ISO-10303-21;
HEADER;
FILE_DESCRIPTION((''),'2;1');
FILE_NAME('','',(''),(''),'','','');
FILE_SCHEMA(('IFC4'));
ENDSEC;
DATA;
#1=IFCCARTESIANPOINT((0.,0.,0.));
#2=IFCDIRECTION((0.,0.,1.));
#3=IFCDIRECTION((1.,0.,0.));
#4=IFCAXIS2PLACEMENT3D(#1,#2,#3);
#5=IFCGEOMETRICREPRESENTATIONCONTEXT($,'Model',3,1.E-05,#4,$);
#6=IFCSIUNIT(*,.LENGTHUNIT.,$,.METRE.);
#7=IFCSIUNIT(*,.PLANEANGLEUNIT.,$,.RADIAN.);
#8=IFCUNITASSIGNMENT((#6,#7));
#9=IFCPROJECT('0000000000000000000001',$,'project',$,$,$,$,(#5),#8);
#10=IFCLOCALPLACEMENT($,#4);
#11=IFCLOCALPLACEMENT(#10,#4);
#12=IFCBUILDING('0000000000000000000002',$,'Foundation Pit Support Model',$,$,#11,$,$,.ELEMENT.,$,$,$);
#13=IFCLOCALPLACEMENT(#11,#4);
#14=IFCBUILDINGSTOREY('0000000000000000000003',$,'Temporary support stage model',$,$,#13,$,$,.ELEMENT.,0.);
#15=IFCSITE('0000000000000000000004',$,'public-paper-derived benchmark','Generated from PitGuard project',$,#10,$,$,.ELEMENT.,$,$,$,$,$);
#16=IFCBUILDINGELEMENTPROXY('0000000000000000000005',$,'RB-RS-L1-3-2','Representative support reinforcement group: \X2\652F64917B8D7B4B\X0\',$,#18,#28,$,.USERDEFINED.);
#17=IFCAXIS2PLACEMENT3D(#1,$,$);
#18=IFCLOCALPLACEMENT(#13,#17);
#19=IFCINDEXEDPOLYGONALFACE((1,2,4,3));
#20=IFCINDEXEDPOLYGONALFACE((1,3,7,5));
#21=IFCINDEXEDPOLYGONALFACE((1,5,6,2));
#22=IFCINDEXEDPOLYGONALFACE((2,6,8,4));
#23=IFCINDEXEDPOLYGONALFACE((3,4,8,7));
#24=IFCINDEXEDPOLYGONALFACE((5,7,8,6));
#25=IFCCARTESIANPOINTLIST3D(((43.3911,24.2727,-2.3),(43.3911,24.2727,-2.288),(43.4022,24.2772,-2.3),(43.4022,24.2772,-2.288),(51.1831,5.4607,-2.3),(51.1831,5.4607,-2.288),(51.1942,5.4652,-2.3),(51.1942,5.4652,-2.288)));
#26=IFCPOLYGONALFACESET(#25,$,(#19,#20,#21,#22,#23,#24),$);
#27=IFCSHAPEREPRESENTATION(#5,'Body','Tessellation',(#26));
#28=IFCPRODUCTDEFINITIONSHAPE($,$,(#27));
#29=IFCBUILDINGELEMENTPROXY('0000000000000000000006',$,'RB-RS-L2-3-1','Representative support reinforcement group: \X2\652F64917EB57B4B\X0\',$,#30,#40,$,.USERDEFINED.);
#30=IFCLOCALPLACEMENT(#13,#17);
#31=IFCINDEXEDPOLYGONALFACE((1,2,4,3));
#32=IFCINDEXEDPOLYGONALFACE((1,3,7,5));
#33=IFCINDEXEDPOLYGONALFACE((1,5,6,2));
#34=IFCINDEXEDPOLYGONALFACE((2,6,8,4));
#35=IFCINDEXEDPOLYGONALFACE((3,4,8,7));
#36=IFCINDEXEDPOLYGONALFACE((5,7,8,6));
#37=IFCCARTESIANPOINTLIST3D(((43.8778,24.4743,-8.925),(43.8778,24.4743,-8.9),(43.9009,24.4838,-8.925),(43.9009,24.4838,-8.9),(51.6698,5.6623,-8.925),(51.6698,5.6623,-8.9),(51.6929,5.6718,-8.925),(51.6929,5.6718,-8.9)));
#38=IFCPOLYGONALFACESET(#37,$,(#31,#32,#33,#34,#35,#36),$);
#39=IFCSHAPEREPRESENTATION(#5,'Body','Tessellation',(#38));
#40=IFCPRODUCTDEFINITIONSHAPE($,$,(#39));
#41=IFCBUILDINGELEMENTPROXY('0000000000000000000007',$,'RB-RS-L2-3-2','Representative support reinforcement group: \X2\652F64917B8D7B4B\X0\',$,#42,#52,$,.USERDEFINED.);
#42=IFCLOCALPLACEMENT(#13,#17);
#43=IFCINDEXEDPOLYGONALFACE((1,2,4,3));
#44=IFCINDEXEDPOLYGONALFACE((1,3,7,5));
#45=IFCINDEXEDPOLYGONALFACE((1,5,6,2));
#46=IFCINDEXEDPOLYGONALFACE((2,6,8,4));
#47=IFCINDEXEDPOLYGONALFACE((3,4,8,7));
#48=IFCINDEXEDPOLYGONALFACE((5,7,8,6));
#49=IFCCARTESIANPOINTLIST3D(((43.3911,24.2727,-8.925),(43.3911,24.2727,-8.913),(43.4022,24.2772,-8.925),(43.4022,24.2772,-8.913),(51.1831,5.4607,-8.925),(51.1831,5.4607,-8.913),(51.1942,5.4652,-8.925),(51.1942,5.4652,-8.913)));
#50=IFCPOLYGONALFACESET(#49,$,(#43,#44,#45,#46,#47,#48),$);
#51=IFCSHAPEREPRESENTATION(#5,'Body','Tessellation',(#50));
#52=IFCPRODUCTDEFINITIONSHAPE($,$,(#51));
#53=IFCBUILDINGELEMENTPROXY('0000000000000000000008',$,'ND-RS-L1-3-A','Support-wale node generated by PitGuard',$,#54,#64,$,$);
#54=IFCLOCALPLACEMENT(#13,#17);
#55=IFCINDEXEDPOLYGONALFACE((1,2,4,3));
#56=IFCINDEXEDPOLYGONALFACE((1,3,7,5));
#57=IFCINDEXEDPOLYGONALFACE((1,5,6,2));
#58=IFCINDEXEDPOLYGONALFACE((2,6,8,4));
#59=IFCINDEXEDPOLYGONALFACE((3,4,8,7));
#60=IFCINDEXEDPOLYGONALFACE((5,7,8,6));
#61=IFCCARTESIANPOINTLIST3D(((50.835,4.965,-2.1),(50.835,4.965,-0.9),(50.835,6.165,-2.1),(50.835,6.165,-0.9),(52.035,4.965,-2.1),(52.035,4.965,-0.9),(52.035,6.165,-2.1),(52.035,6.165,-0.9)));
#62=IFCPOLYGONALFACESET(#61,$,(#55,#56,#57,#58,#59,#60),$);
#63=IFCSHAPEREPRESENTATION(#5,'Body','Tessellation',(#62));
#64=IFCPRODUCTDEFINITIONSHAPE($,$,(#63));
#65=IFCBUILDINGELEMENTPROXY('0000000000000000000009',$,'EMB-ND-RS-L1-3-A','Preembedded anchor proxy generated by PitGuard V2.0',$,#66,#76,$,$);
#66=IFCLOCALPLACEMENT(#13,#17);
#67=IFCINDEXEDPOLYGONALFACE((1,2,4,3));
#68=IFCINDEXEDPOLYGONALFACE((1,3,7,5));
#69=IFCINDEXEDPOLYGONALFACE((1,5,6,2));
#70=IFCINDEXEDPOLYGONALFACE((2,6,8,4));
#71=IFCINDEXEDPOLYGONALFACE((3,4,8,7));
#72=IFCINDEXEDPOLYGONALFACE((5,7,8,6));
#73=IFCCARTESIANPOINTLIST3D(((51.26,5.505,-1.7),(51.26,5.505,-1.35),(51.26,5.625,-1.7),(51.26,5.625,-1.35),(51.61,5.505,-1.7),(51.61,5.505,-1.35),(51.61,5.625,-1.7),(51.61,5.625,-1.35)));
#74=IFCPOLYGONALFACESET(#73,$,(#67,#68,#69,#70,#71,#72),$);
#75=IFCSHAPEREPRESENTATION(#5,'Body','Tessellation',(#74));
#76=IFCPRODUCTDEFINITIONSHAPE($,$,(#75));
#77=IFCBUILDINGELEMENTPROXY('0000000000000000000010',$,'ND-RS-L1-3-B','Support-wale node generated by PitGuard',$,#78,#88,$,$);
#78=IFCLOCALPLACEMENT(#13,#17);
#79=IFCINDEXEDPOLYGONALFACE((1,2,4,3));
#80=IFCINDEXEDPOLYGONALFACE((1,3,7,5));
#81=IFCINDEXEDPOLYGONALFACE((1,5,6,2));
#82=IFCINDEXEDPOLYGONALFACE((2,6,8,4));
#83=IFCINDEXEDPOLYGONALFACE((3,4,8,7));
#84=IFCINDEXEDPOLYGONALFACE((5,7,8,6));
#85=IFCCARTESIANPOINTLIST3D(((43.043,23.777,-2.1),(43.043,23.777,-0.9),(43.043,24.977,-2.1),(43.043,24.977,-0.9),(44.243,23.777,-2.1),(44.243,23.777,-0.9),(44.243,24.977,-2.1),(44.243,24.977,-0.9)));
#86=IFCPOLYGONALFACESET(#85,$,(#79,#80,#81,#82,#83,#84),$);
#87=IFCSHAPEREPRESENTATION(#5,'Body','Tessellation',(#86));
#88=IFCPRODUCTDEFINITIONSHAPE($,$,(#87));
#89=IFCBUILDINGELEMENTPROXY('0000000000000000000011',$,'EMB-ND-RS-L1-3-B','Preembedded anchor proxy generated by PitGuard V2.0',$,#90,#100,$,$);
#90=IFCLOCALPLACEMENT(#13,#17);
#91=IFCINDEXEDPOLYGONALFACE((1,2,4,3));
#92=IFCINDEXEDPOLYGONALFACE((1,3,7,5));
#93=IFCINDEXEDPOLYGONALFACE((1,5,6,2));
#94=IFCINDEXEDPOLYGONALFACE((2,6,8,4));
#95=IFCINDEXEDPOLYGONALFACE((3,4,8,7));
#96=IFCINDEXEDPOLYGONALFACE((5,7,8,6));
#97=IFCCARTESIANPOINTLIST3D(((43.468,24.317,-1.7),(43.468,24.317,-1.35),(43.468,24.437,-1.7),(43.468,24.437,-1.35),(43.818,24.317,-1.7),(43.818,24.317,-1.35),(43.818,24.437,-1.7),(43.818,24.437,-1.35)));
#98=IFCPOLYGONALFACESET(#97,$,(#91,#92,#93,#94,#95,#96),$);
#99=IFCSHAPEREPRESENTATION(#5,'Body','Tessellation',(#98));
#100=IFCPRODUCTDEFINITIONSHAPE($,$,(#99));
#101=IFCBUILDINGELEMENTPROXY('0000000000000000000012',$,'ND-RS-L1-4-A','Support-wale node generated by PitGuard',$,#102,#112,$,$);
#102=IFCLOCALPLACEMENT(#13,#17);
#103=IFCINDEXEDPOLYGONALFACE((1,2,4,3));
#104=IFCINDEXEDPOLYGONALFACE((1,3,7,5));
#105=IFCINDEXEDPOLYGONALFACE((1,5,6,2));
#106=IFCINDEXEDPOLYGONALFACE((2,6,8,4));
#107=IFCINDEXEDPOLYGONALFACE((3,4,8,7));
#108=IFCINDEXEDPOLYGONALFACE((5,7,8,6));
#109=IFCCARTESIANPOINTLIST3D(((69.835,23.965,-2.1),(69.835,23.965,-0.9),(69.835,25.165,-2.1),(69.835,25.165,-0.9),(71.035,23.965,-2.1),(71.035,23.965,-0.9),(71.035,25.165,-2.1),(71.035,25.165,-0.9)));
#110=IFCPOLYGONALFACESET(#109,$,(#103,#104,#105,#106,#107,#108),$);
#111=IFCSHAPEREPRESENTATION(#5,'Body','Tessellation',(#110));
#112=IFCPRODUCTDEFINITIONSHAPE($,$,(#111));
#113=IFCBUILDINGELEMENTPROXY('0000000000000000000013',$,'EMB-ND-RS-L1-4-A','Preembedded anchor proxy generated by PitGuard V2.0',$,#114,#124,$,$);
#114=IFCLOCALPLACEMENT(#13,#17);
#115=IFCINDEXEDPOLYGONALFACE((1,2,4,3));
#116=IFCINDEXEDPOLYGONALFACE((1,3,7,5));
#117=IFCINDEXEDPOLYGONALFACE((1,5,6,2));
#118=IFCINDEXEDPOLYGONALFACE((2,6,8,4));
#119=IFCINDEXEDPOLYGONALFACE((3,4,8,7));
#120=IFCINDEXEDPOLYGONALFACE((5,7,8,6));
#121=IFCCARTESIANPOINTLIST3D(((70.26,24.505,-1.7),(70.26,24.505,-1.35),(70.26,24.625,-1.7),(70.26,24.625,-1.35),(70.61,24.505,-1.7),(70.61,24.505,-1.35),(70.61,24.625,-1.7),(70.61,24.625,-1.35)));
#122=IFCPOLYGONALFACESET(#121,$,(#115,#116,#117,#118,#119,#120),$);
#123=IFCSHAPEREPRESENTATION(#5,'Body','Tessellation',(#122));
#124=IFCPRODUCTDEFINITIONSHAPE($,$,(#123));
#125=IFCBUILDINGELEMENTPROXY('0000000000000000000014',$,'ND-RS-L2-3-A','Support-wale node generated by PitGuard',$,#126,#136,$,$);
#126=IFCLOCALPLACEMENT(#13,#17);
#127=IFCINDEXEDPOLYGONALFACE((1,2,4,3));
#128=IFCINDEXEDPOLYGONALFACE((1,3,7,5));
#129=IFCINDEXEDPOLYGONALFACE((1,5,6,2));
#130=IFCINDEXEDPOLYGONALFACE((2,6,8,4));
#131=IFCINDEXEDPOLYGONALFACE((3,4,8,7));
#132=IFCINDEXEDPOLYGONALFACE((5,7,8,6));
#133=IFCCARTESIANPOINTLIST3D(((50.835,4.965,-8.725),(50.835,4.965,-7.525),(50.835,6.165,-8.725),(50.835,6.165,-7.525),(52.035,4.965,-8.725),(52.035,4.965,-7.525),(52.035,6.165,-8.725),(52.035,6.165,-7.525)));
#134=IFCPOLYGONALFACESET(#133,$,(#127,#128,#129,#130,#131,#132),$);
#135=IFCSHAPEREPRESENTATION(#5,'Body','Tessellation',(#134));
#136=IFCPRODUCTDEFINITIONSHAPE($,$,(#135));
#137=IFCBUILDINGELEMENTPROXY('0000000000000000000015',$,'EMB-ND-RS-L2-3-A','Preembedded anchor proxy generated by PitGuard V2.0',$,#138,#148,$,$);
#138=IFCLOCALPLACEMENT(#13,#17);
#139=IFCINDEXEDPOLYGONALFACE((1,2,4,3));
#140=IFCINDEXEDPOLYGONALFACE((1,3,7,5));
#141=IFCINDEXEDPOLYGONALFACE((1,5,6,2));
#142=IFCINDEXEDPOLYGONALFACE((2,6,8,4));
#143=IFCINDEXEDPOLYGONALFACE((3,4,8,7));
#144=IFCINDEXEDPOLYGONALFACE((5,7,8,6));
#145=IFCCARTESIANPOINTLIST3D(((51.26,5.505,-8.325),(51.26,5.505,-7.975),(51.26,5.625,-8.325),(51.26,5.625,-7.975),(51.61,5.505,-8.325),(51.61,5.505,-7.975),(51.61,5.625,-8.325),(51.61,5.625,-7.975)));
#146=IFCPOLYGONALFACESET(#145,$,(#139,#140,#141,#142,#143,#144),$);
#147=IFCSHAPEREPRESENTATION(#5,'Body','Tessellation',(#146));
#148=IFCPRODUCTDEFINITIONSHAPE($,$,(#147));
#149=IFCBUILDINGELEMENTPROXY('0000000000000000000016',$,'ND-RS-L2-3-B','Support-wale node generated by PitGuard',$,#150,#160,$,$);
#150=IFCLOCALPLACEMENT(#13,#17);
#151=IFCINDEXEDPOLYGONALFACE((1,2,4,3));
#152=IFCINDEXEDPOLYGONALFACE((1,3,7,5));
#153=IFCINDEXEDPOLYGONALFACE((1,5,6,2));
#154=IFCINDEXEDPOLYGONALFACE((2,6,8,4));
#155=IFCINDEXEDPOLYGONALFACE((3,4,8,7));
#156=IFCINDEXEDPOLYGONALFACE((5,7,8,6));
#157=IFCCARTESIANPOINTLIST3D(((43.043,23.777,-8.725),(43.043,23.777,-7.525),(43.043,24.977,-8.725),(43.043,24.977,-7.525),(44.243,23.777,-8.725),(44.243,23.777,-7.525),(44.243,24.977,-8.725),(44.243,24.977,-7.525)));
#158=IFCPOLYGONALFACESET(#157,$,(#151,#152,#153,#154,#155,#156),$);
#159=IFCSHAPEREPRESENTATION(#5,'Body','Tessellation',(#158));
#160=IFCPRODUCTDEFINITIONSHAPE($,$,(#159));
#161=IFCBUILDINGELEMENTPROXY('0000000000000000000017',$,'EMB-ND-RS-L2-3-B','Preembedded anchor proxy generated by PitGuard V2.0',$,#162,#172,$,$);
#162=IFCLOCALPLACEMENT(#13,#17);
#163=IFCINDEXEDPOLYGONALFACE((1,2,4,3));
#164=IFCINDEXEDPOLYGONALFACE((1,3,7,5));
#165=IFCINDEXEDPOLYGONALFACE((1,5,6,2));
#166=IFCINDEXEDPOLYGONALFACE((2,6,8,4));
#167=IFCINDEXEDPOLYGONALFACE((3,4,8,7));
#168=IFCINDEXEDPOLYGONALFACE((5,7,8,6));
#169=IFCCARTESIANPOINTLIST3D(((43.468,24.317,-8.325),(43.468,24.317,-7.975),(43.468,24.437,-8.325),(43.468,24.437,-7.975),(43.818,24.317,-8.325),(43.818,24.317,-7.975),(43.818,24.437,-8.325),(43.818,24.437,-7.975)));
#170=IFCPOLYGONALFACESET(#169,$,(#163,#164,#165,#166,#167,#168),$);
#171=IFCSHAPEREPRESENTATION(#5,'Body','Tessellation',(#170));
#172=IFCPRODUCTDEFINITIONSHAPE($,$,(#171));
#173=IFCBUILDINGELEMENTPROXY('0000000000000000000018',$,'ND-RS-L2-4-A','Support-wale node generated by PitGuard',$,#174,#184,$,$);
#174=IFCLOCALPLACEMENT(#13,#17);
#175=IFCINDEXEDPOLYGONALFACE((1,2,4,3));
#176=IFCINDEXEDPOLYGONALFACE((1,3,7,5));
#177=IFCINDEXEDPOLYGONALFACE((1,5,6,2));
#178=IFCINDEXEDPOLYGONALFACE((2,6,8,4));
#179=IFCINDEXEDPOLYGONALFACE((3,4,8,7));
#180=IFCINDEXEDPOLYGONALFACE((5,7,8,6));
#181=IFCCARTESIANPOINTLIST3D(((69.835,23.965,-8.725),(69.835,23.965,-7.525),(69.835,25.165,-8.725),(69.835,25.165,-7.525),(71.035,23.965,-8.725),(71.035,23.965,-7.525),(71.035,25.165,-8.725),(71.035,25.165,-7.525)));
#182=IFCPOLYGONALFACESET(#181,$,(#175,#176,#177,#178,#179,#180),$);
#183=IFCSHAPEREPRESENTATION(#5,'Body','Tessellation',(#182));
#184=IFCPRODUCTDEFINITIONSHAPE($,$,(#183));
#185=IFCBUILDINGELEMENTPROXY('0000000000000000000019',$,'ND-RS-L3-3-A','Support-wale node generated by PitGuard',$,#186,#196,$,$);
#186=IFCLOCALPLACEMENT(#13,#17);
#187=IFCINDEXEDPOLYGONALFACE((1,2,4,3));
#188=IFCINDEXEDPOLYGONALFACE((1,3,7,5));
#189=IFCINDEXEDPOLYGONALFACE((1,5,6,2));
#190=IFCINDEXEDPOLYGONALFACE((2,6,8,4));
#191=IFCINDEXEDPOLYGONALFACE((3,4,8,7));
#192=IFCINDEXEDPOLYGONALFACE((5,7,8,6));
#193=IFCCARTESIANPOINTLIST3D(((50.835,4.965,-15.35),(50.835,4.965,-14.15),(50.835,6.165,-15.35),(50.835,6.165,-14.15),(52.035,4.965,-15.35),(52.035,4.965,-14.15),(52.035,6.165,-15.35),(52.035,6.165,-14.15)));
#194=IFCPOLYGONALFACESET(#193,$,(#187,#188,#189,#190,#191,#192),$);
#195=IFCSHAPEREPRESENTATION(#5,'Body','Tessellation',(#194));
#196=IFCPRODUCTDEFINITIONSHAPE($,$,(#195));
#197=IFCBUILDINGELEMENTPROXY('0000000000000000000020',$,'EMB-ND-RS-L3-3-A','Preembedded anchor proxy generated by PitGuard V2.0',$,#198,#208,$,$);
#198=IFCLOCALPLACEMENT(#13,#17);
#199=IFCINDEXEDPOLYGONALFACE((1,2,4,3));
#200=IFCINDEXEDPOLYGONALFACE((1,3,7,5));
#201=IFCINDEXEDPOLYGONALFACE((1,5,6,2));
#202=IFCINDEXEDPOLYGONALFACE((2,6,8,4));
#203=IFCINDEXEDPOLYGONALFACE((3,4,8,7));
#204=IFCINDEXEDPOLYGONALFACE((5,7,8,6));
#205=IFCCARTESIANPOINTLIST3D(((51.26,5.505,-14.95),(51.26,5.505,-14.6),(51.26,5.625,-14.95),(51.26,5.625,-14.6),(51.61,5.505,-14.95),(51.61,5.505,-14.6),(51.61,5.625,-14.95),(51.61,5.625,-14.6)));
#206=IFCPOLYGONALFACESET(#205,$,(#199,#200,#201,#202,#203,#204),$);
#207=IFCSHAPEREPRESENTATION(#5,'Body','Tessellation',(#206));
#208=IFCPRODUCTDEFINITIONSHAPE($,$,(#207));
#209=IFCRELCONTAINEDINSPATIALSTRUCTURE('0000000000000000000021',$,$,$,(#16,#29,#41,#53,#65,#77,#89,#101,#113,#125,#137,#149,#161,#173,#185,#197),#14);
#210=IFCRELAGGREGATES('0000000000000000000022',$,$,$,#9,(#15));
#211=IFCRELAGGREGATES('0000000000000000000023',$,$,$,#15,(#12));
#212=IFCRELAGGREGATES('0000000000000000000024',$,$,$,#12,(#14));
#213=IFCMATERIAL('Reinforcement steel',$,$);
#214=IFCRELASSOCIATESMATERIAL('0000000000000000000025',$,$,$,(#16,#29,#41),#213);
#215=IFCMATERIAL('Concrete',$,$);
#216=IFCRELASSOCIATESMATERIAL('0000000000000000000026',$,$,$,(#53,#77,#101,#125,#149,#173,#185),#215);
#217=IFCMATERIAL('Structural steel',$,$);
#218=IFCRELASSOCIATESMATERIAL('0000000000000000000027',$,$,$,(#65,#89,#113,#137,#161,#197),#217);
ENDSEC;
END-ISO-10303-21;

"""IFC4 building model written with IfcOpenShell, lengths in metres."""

from ifc_helpers import new_model, si_unit, frame, origin_with_axes, origin_2d, place, context, project, spatial, rectangle, extrude, material, element, save


model = new_model("IFC4")

# Units and contexts
model_context = context("Model", 3, precision=1e-05, world=origin_with_axes())
ifc_project = project(units=[si_unit("LENGTHUNIT", "METRE"), si_unit("PLANEANGLEUNIT", "RADIAN")], contexts=[model_context])

# Site, building, storey
site_placement = place(None, origin_with_axes())
site = spatial("IfcSite", under=ifc_project, at=site_placement, Name="public-paper-derived benchmark", Description="Generated from PitGuard project", CompositionType="ELEMENT")
building_placement = place(site_placement, origin_with_axes())
building = spatial("IfcBuilding", under=site, at=building_placement, Name="Foundation Pit Support Model", CompositionType="ELEMENT")
storey_placement = place(building_placement, origin_with_axes())
storey = spatial("IfcBuildingStorey", under=building, at=storey_placement, Name="Temporary support stage model", CompositionType="ELEMENT", Elevation=0.0)

# Shared definitions
ifc_material_1 = material(Name="Concrete")

# Shared definitions
ifc_material_2 = material(Name="Structural steel")

# Building element proxies
ifc_material_3 = material(Name="Reinforcement steel")
proxy_1_placement = place(storey_placement, frame((47.2926, 14.869, -2.3), z_axis=(0.0, 0.0, 1.0), x_axis=(-0.382676, 0.923883, 0.0)))
element("IfcBuildingElementProxy", 1, at=proxy_1_placement, inside=storey, material=ifc_material_3, Name="RB-RS-L1-3-2", Description="Representative support reinforcement group: 支撑箍筋", PredefinedType="USERDEFINED", context=model_context, shape_type="SweptSolid", body=[
    extrude(rectangle(XDim=20.3619, YDim=0.012, at=origin_2d()), origin_with_axes(), (0.0, 0.0, 1.0), 0.012),
])
proxy_2_placement = place(storey_placement, frame((47.7854, 15.073, -8.925), z_axis=(0.0, 0.0, 1.0), x_axis=(-0.382676, 0.923883, 0.0)))
element("IfcBuildingElementProxy", 2, at=proxy_2_placement, inside=storey, material=ifc_material_3, Name="RB-RS-L2-3-1", Description="Representative support reinforcement group: 支撑纵筋", PredefinedType="USERDEFINED", context=model_context, shape_type="SweptSolid", body=[
    extrude(rectangle(XDim=20.3619, YDim=0.025, at=origin_2d()), origin_with_axes(), (0.0, 0.0, 1.0), 0.025),
])
proxy_3_placement = place(storey_placement, frame((47.2926, 14.869, -8.925), z_axis=(0.0, 0.0, 1.0), x_axis=(-0.382676, 0.923883, 0.0)))
element("IfcBuildingElementProxy", 3, at=proxy_3_placement, inside=storey, material=ifc_material_3, Name="RB-RS-L2-3-2", Description="Representative support reinforcement group: 支撑箍筋", PredefinedType="USERDEFINED", context=model_context, shape_type="SweptSolid", body=[
    extrude(rectangle(XDim=20.3619, YDim=0.012, at=origin_2d()), origin_with_axes(), (0.0, 0.0, 1.0), 0.012),
])
proxy_4_placement = place(storey_placement, frame((51.435, 5.565, -2.1), z_axis=(0.0, 0.0, 1.0), x_axis=(1.0, 0.0, 0.0)))
element("IfcBuildingElementProxy", 4, at=proxy_4_placement, inside=storey, material=ifc_material_1, Name="ND-RS-L1-3-A", Description="Support-wale node generated by PitGuard", context=model_context, shape_type="SweptSolid", body=[
    extrude(rectangle(XDim=1.2, YDim=1.2, at=origin_2d()), origin_with_axes(), (0.0, 0.0, 1.0), 1.2),
])
proxy_5_placement = place(storey_placement, frame((51.435, 5.565, -1.7), z_axis=(0.0, 0.0, 1.0), x_axis=(1.0, 0.0, 0.0)))
element("IfcBuildingElementProxy", 5, at=proxy_5_placement, inside=storey, material=ifc_material_2, Name="EMB-ND-RS-L1-3-A", Description="Preembedded anchor proxy generated by PitGuard V2.0", context=model_context, shape_type="SweptSolid", body=[
    extrude(rectangle(XDim=0.35, YDim=0.12, at=origin_2d()), origin_with_axes(), (0.0, 0.0, 1.0), 0.35),
])
proxy_6_placement = place(storey_placement, frame((43.643, 24.377, -2.1), z_axis=(0.0, 0.0, 1.0), x_axis=(1.0, 0.0, 0.0)))
element("IfcBuildingElementProxy", 6, at=proxy_6_placement, inside=storey, material=ifc_material_1, Name="ND-RS-L1-3-B", Description="Support-wale node generated by PitGuard", context=model_context, shape_type="SweptSolid", body=[
    extrude(rectangle(XDim=1.2, YDim=1.2, at=origin_2d()), origin_with_axes(), (0.0, 0.0, 1.0), 1.2),
])
proxy_7_placement = place(storey_placement, frame((43.643, 24.377, -1.7), z_axis=(0.0, 0.0, 1.0), x_axis=(1.0, 0.0, 0.0)))
element("IfcBuildingElementProxy", 7, at=proxy_7_placement, inside=storey, material=ifc_material_2, Name="EMB-ND-RS-L1-3-B", Description="Preembedded anchor proxy generated by PitGuard V2.0", context=model_context, shape_type="SweptSolid", body=[
    extrude(rectangle(XDim=0.35, YDim=0.12, at=origin_2d()), origin_with_axes(), (0.0, 0.0, 1.0), 0.35),
])
proxy_8_placement = place(storey_placement, frame((70.435, 24.565, -2.1), z_axis=(0.0, 0.0, 1.0), x_axis=(1.0, 0.0, 0.0)))
element("IfcBuildingElementProxy", 8, at=proxy_8_placement, inside=storey, material=ifc_material_1, Name="ND-RS-L1-4-A", Description="Support-wale node generated by PitGuard", context=model_context, shape_type="SweptSolid", body=[
    extrude(rectangle(XDim=1.2, YDim=1.2, at=origin_2d()), origin_with_axes(), (0.0, 0.0, 1.0), 1.2),
])
proxy_9_placement = place(storey_placement, frame((70.435, 24.565, -1.7), z_axis=(0.0, 0.0, 1.0), x_axis=(1.0, 0.0, 0.0)))
element("IfcBuildingElementProxy", 9, at=proxy_9_placement, inside=storey, material=ifc_material_2, Name="EMB-ND-RS-L1-4-A", Description="Preembedded anchor proxy generated by PitGuard V2.0", context=model_context, shape_type="SweptSolid", body=[
    extrude(rectangle(XDim=0.35, YDim=0.12, at=origin_2d()), origin_with_axes(), (0.0, 0.0, 1.0), 0.35),
])
proxy_10_placement = place(storey_placement, frame((51.435, 5.565, -8.725), z_axis=(0.0, 0.0, 1.0), x_axis=(1.0, 0.0, 0.0)))
element("IfcBuildingElementProxy", 10, at=proxy_10_placement, inside=storey, material=ifc_material_1, Name="ND-RS-L2-3-A", Description="Support-wale node generated by PitGuard", context=model_context, shape_type="SweptSolid", body=[
    extrude(rectangle(XDim=1.2, YDim=1.2, at=origin_2d()), origin_with_axes(), (0.0, 0.0, 1.0), 1.2),
])
proxy_11_placement = place(storey_placement, frame((51.435, 5.565, -8.325), z_axis=(0.0, 0.0, 1.0), x_axis=(1.0, 0.0, 0.0)))
element("IfcBuildingElementProxy", 11, at=proxy_11_placement, inside=storey, material=ifc_material_2, Name="EMB-ND-RS-L2-3-A", Description="Preembedded anchor proxy generated by PitGuard V2.0", context=model_context, shape_type="SweptSolid", body=[
    extrude(rectangle(XDim=0.35, YDim=0.12, at=origin_2d()), origin_with_axes(), (0.0, 0.0, 1.0), 0.35),
])
proxy_12_placement = place(storey_placement, frame((43.643, 24.377, -8.725), z_axis=(0.0, 0.0, 1.0), x_axis=(1.0, 0.0, 0.0)))
element("IfcBuildingElementProxy", 12, at=proxy_12_placement, inside=storey, material=ifc_material_1, Name="ND-RS-L2-3-B", Description="Support-wale node generated by PitGuard", context=model_context, shape_type="SweptSolid", body=[
    extrude(rectangle(XDim=1.2, YDim=1.2, at=origin_2d()), origin_with_axes(), (0.0, 0.0, 1.0), 1.2),
])
proxy_13_placement = place(storey_placement, frame((43.643, 24.377, -8.325), z_axis=(0.0, 0.0, 1.0), x_axis=(1.0, 0.0, 0.0)))
element("IfcBuildingElementProxy", 13, at=proxy_13_placement, inside=storey, material=ifc_material_2, Name="EMB-ND-RS-L2-3-B", Description="Preembedded anchor proxy generated by PitGuard V2.0", context=model_context, shape_type="SweptSolid", body=[
    extrude(rectangle(XDim=0.35, YDim=0.12, at=origin_2d()), origin_with_axes(), (0.0, 0.0, 1.0), 0.35),
])
for number, where, z_axis, x_axis, name in (
    (14, (70.435, 24.565, -8.725), (0.0, 0.0, 1.0), (1.0, 0.0, 0.0), "ND-RS-L2-4-A"),
    (15, (51.435, 5.565, -15.35), (0.0, 0.0, 1.0), (1.0, 0.0, 0.0), "ND-RS-L3-3-A"),
):
    element("IfcBuildingElementProxy", number, at=place(storey_placement, frame(where, z_axis=z_axis, x_axis=x_axis)), inside=storey, material=ifc_material_1, Name=name, Description="Support-wale node generated by PitGuard", context=model_context, shape_type="SweptSolid", body=[
        extrude(rectangle(XDim=1.2, YDim=1.2, at=origin_2d()), origin_with_axes(), (0.0, 0.0, 1.0), 1.2),
    ])
proxy_14_placement = place(storey_placement, frame((51.435, 5.565, -14.95), z_axis=(0.0, 0.0, 1.0), x_axis=(1.0, 0.0, 0.0)))
element("IfcBuildingElementProxy", 16, at=proxy_14_placement, inside=storey, material=ifc_material_2, Name="EMB-ND-RS-L3-3-A", Description="Preembedded anchor proxy generated by PitGuard V2.0", context=model_context, shape_type="SweptSolid", body=[
    extrude(rectangle(XDim=0.35, YDim=0.12, at=origin_2d()), origin_with_axes(), (0.0, 0.0, 1.0), 0.35),
])

save(model, "model.ifc")
